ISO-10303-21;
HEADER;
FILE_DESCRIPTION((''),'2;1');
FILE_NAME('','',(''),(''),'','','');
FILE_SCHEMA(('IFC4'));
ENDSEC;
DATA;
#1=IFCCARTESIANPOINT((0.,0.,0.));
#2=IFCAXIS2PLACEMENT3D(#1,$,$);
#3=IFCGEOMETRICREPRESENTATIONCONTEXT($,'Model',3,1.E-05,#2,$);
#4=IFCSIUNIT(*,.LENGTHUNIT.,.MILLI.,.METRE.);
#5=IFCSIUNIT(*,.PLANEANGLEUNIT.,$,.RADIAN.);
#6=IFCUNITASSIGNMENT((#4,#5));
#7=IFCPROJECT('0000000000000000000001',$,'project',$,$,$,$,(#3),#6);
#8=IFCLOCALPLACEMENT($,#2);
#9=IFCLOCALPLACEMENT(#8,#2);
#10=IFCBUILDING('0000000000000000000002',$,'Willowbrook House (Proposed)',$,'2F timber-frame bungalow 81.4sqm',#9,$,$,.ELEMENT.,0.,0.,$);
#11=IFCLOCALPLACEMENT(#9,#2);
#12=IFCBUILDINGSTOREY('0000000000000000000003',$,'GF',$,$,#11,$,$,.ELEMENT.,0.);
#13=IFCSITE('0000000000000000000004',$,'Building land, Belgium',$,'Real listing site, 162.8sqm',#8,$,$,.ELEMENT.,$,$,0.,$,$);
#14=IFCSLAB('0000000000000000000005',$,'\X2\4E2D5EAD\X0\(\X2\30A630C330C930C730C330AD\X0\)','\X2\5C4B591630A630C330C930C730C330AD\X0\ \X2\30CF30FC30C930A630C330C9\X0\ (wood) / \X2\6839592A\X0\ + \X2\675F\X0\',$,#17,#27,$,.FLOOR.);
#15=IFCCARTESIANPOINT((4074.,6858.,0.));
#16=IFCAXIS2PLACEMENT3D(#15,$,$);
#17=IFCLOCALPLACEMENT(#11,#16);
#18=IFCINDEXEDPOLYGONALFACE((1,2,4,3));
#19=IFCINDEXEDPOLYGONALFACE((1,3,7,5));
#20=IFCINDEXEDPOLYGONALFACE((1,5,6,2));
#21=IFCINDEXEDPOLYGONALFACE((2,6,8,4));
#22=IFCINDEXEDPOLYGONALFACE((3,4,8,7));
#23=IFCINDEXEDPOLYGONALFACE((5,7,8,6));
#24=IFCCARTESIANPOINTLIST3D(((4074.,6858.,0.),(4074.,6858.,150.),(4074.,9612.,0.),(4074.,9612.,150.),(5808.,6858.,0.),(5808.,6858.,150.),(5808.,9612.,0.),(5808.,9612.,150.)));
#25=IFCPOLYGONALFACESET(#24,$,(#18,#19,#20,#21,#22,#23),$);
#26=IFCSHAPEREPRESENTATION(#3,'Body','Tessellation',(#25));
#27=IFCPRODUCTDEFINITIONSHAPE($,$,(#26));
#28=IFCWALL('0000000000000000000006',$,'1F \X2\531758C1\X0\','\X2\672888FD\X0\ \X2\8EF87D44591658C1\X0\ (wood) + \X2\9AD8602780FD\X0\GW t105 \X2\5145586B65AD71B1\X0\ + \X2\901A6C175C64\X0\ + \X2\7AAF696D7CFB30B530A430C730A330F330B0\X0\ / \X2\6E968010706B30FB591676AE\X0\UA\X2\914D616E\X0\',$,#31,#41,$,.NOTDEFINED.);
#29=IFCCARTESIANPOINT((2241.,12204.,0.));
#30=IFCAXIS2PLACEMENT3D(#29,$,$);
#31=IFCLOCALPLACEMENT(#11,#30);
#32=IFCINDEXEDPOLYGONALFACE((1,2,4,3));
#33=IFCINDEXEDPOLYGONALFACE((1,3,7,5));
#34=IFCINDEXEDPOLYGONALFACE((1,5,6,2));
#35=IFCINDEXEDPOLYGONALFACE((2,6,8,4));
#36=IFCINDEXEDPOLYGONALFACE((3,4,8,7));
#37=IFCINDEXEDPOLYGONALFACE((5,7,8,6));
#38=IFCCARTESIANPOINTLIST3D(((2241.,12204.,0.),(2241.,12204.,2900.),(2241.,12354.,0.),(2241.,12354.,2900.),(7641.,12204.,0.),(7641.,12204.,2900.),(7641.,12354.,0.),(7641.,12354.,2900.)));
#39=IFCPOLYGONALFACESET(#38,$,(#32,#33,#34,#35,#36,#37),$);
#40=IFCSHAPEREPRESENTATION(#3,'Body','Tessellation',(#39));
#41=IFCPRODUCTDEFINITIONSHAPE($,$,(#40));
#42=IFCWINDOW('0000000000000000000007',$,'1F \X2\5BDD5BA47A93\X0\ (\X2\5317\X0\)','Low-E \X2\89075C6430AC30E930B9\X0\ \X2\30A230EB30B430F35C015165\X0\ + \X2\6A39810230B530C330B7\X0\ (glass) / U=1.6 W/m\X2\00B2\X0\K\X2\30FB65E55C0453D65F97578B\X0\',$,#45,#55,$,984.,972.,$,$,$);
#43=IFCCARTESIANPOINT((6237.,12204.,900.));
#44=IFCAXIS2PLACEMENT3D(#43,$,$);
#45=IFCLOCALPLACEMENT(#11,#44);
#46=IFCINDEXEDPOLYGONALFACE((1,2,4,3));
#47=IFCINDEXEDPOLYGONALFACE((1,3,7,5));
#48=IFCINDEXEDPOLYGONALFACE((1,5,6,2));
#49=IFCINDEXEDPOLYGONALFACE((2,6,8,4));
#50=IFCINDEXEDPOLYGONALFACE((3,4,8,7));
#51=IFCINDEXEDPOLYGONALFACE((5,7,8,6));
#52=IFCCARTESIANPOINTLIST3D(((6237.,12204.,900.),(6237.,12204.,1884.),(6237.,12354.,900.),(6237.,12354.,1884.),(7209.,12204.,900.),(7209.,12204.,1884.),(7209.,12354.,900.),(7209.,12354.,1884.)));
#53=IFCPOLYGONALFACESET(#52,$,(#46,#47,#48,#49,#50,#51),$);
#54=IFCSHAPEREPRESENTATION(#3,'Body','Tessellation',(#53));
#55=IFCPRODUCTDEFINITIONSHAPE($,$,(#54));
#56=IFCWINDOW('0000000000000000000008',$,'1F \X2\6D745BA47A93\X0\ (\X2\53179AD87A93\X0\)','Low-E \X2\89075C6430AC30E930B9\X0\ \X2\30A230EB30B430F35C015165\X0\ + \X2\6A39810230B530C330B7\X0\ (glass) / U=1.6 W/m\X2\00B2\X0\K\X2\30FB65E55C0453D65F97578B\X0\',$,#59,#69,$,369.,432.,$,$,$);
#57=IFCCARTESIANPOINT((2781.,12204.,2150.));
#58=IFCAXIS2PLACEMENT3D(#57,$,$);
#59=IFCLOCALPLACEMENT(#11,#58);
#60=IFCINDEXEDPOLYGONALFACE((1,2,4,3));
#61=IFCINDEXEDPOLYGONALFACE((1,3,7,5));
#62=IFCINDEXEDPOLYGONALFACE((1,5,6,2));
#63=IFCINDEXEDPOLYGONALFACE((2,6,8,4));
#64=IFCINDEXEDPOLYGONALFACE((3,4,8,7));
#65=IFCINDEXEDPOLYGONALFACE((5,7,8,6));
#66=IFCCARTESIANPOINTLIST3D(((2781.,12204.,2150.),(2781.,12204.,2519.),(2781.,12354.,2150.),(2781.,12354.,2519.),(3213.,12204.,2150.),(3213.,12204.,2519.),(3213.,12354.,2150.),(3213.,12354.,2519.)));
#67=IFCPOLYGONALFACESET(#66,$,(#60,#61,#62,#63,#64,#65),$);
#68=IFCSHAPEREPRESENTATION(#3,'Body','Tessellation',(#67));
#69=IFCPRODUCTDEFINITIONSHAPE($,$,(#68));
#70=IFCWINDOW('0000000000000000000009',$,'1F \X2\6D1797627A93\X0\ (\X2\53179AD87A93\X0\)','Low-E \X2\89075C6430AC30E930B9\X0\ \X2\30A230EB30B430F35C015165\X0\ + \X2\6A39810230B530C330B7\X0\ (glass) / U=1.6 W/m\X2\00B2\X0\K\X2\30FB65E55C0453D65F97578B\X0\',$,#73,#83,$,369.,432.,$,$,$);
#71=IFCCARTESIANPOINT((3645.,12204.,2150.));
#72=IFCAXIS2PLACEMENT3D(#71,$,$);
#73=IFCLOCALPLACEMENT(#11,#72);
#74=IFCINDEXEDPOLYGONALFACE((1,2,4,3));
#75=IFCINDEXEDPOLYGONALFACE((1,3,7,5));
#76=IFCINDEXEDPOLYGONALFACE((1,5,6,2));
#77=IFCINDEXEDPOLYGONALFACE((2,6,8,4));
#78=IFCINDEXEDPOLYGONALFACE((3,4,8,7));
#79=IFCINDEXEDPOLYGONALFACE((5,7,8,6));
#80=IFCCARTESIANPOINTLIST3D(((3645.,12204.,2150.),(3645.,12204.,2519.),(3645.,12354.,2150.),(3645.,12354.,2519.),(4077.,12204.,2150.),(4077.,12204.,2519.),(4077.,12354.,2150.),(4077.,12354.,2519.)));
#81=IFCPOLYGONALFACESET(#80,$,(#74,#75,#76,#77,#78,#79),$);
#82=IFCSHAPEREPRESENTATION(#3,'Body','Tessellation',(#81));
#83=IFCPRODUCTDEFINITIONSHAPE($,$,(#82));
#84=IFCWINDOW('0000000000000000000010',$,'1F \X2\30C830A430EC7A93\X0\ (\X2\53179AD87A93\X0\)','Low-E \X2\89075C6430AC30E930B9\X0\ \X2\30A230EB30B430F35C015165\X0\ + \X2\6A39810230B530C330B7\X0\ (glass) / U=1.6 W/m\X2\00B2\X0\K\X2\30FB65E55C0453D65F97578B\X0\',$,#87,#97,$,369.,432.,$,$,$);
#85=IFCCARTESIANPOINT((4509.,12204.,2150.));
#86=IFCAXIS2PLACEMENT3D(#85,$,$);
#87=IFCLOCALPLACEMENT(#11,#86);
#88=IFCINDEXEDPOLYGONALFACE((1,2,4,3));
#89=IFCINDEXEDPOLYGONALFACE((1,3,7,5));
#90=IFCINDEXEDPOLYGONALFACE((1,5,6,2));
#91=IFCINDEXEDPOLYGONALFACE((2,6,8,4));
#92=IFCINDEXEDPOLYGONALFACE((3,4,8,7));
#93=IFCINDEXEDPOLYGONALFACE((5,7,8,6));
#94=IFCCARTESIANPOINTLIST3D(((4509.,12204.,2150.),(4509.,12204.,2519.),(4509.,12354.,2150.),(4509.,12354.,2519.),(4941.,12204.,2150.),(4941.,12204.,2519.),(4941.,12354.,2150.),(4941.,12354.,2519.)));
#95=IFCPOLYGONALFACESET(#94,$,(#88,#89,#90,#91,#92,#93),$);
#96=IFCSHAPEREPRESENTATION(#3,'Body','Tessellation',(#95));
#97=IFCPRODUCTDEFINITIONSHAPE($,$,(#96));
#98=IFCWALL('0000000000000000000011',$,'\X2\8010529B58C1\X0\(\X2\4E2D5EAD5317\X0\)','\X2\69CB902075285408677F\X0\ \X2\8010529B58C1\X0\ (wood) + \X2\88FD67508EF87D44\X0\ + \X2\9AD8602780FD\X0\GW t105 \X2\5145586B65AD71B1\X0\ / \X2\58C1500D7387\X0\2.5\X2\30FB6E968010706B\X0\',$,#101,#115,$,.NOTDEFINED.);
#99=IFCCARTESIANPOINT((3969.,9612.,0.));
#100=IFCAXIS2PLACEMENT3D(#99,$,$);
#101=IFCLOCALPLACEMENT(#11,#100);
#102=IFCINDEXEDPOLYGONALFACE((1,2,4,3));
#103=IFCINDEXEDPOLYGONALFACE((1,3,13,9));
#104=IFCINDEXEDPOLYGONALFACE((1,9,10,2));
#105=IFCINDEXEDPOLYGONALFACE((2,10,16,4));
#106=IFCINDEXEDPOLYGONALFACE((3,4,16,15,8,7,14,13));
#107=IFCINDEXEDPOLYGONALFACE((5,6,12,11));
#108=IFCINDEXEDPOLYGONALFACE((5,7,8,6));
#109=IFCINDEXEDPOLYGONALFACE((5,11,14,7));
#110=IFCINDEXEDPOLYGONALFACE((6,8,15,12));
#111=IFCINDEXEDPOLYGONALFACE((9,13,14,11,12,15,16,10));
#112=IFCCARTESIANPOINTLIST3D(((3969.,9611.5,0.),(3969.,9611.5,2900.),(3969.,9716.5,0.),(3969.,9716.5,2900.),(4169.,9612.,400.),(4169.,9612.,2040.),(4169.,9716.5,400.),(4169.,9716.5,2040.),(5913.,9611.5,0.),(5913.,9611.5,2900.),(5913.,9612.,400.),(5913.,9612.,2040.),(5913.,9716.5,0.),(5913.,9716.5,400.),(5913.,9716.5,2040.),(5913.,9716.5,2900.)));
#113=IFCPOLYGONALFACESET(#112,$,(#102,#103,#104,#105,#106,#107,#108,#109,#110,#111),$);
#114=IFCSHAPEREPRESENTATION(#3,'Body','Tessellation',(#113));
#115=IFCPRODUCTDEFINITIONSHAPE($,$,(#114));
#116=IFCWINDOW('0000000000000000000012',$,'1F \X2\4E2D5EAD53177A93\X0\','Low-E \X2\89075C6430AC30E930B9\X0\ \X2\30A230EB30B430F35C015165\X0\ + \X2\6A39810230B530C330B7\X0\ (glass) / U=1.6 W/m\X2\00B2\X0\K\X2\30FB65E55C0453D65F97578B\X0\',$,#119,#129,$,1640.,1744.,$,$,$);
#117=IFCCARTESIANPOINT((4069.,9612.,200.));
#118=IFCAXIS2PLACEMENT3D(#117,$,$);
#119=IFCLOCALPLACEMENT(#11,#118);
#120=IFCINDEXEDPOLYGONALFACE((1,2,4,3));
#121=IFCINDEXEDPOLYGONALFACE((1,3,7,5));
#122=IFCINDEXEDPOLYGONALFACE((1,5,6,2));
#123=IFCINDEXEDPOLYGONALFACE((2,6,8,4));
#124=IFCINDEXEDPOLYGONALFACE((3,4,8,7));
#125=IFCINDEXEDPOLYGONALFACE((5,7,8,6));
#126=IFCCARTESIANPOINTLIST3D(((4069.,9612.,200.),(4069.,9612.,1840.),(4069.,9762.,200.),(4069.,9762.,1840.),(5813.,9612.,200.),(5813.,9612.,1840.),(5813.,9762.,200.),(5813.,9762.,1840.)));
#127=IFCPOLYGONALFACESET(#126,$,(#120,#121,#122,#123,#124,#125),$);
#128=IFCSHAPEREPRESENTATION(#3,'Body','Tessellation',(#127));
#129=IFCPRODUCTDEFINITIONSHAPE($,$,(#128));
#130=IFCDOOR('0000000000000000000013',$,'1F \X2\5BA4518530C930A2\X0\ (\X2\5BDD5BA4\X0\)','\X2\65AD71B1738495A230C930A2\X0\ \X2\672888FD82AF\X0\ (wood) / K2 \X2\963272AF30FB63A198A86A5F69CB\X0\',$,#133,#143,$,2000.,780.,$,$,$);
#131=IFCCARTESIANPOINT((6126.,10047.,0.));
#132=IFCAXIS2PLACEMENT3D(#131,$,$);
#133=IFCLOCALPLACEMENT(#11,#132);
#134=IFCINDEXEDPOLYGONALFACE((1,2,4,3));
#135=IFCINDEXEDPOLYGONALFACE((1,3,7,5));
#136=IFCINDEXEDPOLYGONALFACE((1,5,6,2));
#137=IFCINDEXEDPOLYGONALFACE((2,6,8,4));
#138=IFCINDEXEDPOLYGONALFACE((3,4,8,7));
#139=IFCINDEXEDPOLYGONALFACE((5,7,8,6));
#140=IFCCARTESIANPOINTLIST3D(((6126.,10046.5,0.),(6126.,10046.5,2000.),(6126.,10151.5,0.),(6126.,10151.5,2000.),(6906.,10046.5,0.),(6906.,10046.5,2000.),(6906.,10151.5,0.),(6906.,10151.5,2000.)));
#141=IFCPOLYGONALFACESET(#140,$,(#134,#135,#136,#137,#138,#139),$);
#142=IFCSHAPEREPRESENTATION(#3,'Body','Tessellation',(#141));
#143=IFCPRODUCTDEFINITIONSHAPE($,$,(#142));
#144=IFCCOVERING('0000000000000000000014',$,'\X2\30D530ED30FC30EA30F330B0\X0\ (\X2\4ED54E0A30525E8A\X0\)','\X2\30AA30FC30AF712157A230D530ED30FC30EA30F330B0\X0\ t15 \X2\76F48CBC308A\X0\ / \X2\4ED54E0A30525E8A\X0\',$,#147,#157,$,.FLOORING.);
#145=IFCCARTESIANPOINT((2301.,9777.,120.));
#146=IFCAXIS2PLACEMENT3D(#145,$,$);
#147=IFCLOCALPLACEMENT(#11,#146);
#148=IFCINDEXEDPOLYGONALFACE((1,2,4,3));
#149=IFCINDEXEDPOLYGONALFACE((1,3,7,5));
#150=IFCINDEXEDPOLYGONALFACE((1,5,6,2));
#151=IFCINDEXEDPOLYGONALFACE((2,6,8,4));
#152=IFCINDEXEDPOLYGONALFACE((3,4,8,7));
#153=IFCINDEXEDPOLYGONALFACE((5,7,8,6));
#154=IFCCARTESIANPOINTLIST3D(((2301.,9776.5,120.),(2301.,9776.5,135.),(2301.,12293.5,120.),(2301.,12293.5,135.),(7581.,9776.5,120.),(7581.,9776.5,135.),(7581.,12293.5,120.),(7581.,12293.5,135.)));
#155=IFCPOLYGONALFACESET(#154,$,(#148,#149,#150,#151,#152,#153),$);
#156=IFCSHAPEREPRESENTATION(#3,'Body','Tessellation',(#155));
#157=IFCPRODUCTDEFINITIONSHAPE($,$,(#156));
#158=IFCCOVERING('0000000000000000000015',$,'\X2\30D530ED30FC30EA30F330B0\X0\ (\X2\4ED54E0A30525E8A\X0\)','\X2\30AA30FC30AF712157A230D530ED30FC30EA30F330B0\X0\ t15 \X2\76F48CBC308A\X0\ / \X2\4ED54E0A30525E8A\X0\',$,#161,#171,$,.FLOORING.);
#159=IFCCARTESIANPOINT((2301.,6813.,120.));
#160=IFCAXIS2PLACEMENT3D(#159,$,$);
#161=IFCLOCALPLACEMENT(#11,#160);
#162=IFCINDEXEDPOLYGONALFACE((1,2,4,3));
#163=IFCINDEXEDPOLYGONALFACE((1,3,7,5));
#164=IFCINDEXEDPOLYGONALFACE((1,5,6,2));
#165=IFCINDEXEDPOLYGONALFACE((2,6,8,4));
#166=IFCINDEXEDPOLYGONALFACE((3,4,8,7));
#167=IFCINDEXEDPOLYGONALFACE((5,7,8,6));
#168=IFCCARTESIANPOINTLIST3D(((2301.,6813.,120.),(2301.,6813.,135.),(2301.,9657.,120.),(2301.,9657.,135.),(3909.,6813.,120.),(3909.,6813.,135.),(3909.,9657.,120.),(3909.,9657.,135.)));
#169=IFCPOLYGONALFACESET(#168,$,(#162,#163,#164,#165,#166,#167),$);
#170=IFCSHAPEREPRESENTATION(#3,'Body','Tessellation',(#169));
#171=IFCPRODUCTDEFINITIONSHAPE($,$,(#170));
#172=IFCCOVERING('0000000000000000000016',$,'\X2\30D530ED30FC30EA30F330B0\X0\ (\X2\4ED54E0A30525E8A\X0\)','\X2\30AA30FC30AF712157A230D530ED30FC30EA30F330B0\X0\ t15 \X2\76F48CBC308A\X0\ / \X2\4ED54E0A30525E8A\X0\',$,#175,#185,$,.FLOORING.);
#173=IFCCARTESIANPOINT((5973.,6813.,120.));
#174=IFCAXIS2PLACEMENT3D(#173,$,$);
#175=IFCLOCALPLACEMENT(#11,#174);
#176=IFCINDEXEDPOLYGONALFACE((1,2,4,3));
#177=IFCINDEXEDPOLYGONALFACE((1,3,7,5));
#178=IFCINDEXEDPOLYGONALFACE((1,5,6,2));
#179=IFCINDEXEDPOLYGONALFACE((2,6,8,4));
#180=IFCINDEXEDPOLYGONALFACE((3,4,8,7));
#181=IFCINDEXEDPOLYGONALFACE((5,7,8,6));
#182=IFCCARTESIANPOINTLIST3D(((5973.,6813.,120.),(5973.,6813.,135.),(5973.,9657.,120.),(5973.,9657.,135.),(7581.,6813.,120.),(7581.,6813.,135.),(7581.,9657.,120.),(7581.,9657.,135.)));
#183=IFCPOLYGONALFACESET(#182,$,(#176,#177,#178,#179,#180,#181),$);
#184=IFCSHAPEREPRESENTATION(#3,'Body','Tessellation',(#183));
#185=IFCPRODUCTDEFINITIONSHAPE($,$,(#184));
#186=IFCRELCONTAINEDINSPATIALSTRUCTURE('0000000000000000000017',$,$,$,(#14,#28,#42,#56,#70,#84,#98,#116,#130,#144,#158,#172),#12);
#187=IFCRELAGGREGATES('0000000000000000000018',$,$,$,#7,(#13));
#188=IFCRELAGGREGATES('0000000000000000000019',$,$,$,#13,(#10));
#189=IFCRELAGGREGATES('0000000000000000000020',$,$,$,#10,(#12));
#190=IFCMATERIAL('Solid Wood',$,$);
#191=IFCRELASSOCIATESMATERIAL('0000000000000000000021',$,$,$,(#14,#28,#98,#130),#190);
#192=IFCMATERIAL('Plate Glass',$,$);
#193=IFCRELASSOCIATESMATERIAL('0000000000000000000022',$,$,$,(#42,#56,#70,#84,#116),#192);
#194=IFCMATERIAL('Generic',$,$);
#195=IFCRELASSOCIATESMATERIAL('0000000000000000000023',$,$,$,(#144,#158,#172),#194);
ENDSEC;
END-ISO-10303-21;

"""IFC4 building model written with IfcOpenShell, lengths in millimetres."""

from ifc_helpers import new_model, si_unit, frame, frame_2d, origin, place, context, project, spatial, rectangle, extrude, material, element, fill, save


model = new_model("IFC4")

# Units and contexts
model_context = context("Model", 3, precision=1e-05, world=origin())
ifc_project = project(units=[si_unit("LENGTHUNIT", "METRE", prefix="MILLI"), si_unit("PLANEANGLEUNIT", "RADIAN")], contexts=[model_context])

# Site, building, storey
site_placement = place(None, origin())
site = spatial("IfcSite", under=ifc_project, at=site_placement, Name="Building land, Belgium", ObjectType="Real listing site, 162.8sqm", CompositionType="ELEMENT", RefElevation=0.0)
building_placement = place(site_placement, origin())
building = spatial("IfcBuilding", under=site, at=building_placement, Name="Willowbrook House (Proposed)", ObjectType="2F timber-frame bungalow 81.4sqm", CompositionType="ELEMENT", ElevationOfRefHeight=0.0, ElevationOfTerrain=0.0)
storey_placement = place(building_placement, origin())
storey = spatial("IfcBuildingStorey", under=building, at=storey_placement, Name="GF", CompositionType="ELEMENT", Elevation=0.0)

# Slab
ifc_material_1 = material(Name="Solid Wood")
slab_1_placement = place(storey_placement, frame((4074.0, 6858.0, 0.0)))
element("IfcSlab", 1, at=slab_1_placement, inside=storey, material=ifc_material_1, Name="中庭(ウッドデッキ)", Description="屋外ウッドデッキ ハードウッド (wood) / 根太 + 束", PredefinedType="FLOOR", context=model_context, shape_type="SweptSolid", body=[
    extrude(rectangle(XDim=1734.0, YDim=2754.0, at=frame_2d((867.0, 1377.0))), frame((4074.0, 6858.0, 0.0)), (0.0, 0.0, 1.0), 150.0),
])

# Wall, openings, windows
wall_1_placement = place(storey_placement, frame((2241.0, 12204.0, 0.0)))
wall_1 = element("IfcWall", 2, at=wall_1_placement, inside=storey, material=ifc_material_1, Name="1F 北壁", Description="木製 軸組外壁 (wood) + 高性能GW t105 充填断熱 + 通気層 + 窯業系サイディング / 準耐火・外皮UA配慮", PredefinedType="NOTDEFINED", context=model_context, shape_type="SweptSolid", body=[
    extrude(rectangle(XDim=5400.0, YDim=150.0, at=frame_2d((2700.0, 75.0))), frame((2241.0, 12204.0, 0.0)), (0.0, 0.0, 1.0), 2900.0),
])
opening_1_placement = place(storey_placement, frame((6237.0, 12204.0, 900.0)))
opening_1 = element("IfcOpeningElement", 3, at=opening_1_placement, cuts=wall_1, PredefinedType="NOTDEFINED", context=model_context, shape_type="SweptSolid", body=[
    extrude(rectangle(XDim=972.0, YDim=150.0, at=frame_2d((486.0, 75.0))), frame((6237.0, 12204.0, 900.0)), (0.0, 0.0, 1.0), 984.0),
])
opening_2_placement = place(storey_placement, frame((2781.0, 12204.0, 2150.0)))
opening_2 = element("IfcOpeningElement", 4, at=opening_2_placement, cuts=wall_1, PredefinedType="NOTDEFINED", context=model_context, shape_type="SweptSolid", body=[
    extrude(rectangle(XDim=432.0, YDim=150.0, at=frame_2d((216.0, 75.0))), frame((2781.0, 12204.0, 2150.0)), (0.0, 0.0, 1.0), 369.0),
])
opening_3_placement = place(storey_placement, frame((3645.0, 12204.0, 2150.0)))
opening_3 = element("IfcOpeningElement", 5, at=opening_3_placement, cuts=wall_1, PredefinedType="NOTDEFINED", context=model_context, shape_type="SweptSolid", body=[
    extrude(rectangle(XDim=432.0, YDim=150.0, at=frame_2d((216.0, 75.0))), frame((3645.0, 12204.0, 2150.0)), (0.0, 0.0, 1.0), 369.0),
])
opening_4_placement = place(storey_placement, frame((4509.0, 12204.0, 2150.0)))
opening_4 = element("IfcOpeningElement", 6, at=opening_4_placement, cuts=wall_1, PredefinedType="NOTDEFINED", context=model_context, shape_type="SweptSolid", body=[
    extrude(rectangle(XDim=432.0, YDim=150.0, at=frame_2d((216.0, 75.0))), frame((4509.0, 12204.0, 2150.0)), (0.0, 0.0, 1.0), 369.0),
])
ifc_material_2 = material(Name="Plate Glass")
window_1_placement = place(storey_placement, frame((6237.0, 12204.0, 900.0)))
window_1 = element("IfcWindow", 7, at=window_1_placement, inside=storey, material=ifc_material_2, Name="1F 寝室窓 (北)", Description="Low-E 複層ガラス アルゴン封入 + 樹脂サッシ (glass) / U=1.6 W/m²K・日射取得型", OverallHeight=984.0, OverallWidth=972.0, context=model_context, shape_type="SweptSolid", body=[
    extrude(rectangle(XDim=972.0, YDim=150.0, at=frame_2d((486.0, 75.0))), frame((6237.0, 12204.0, 900.0)), (0.0, 0.0, 1.0), 984.0),
])
fill(opening_1, window_1)
window_2_placement = place(storey_placement, frame((2781.0, 12204.0, 2150.0)))
window_2 = element("IfcWindow", 8, at=window_2_placement, inside=storey, material=ifc_material_2, Name="1F 浴室窓 (北高窓)", Description="Low-E 複層ガラス アルゴン封入 + 樹脂サッシ (glass) / U=1.6 W/m²K・日射取得型", OverallHeight=369.0, OverallWidth=432.0, context=model_context, shape_type="SweptSolid", body=[
    extrude(rectangle(XDim=432.0, YDim=150.0, at=frame_2d((216.0, 75.0))), frame((2781.0, 12204.0, 2150.0)), (0.0, 0.0, 1.0), 369.0),
])
fill(opening_2, window_2)
window_3_placement = place(storey_placement, frame((3645.0, 12204.0, 2150.0)))
window_3 = element("IfcWindow", 9, at=window_3_placement, inside=storey, material=ifc_material_2, Name="1F 洗面窓 (北高窓)", Description="Low-E 複層ガラス アルゴン封入 + 樹脂サッシ (glass) / U=1.6 W/m²K・日射取得型", OverallHeight=369.0, OverallWidth=432.0, context=model_context, shape_type="SweptSolid", body=[
    extrude(rectangle(XDim=432.0, YDim=150.0, at=frame_2d((216.0, 75.0))), frame((3645.0, 12204.0, 2150.0)), (0.0, 0.0, 1.0), 369.0),
])
fill(opening_3, window_3)
window_4_placement = place(storey_placement, frame((4509.0, 12204.0, 2150.0)))
window_4 = element("IfcWindow", 10, at=window_4_placement, inside=storey, material=ifc_material_2, Name="1F トイレ窓 (北高窓)", Description="Low-E 複層ガラス アルゴン封入 + 樹脂サッシ (glass) / U=1.6 W/m²K・日射取得型", OverallHeight=369.0, OverallWidth=432.0, context=model_context, shape_type="SweptSolid", body=[
    extrude(rectangle(XDim=432.0, YDim=150.0, at=frame_2d((216.0, 75.0))), frame((4509.0, 12204.0, 2150.0)), (0.0, 0.0, 1.0), 369.0),
])
fill(opening_4, window_4)

# Wall, opening, window
wall_2_placement = place(storey_placement, frame((3969.0, 9612.0, 0.0)))
wall_2 = element("IfcWall", 11, at=wall_2_placement, inside=storey, material=ifc_material_1, Name="耐力壁(中庭北)", Description="構造用合板 耐力壁 (wood) + 製材軸組 + 高性能GW t105 充填断熱 / 壁倍率2.5・準耐火", PredefinedType="NOTDEFINED", context=model_context, shape_type="SweptSolid", body=[
    extrude(rectangle(XDim=1944.0, YDim=105.0, at=frame_2d((972.0, 52.0))), frame((3969.0, 9612.0, 0.0)), (0.0, 0.0, 1.0), 2900.0),
])
opening_5_placement = place(storey_placement, frame((4069.0, 9612.0, 200.0)))
opening_5 = element("IfcOpeningElement", 12, at=opening_5_placement, cuts=wall_2, PredefinedType="NOTDEFINED", context=model_context, shape_type="SweptSolid", body=[
    extrude(rectangle(XDim=1744.0, YDim=150.0, at=frame_2d((872.0, 75.0))), frame((4069.0, 9612.0, 200.0)), (0.0, 0.0, 1.0), 1640.0),
])
window_5_placement = place(storey_placement, frame((4069.0, 9612.0, 200.0)))
window_5 = element("IfcWindow", 13, at=window_5_placement, inside=storey, material=ifc_material_2, Name="1F 中庭北窓", Description="Low-E 複層ガラス アルゴン封入 + 樹脂サッシ (glass) / U=1.6 W/m²K・日射取得型", OverallHeight=1640.0, OverallWidth=1744.0, context=model_context, shape_type="SweptSolid", body=[
    extrude(rectangle(XDim=1744.0, YDim=150.0, at=frame_2d((872.0, 75.0))), frame((4069.0, 9612.0, 200.0)), (0.0, 0.0, 1.0), 1640.0),
])
fill(opening_5, window_5)

# Door
door_1_placement = place(storey_placement, frame((6126.0, 10047.0, 0.0)))
element("IfcDoor", 14, at=door_1_placement, inside=storey, material=ifc_material_1, Name="1F 室内ドア (寝室)", Description="断熱玄関ドア 木製芯 (wood) / K2 防犯・採風機構", OverallHeight=2000.0, OverallWidth=780.0, context=model_context, shape_type="SweptSolid", body=[
    extrude(rectangle(XDim=780.0, YDim=105.0, at=frame_2d((390.0, 52.0))), frame((6126.0, 10047.0, 0.0)), (0.0, 0.0, 1.0), 2000.0),
])

# Coverings
ifc_material_3 = material(Name="Generic")
covering_1_placement = place(storey_placement, frame((2301.0, 9777.0, 120.0)))
element("IfcCovering", 15, at=covering_1_placement, inside=storey, material=ifc_material_3, Name="フローリング (仕上げ床)", Description="オーク無垢フローリング t15 直貼り / 仕上げ床", PredefinedType="FLOORING", context=model_context, shape_type="SweptSolid", body=[
    extrude(rectangle(XDim=5280.0, YDim=2517.0, at=frame_2d((2640.0, 1258.0))), frame((2301.0, 9777.0, 120.0)), (0.0, 0.0, 1.0), 15.0),
])
covering_2_placement = place(storey_placement, frame((2301.0, 6813.0, 120.0)))
element("IfcCovering", 16, at=covering_2_placement, inside=storey, material=ifc_material_3, Name="フローリング (仕上げ床)", Description="オーク無垢フローリング t15 直貼り / 仕上げ床", PredefinedType="FLOORING", context=model_context, shape_type="SweptSolid", body=[
    extrude(rectangle(XDim=1608.0, YDim=2844.0, at=frame_2d((804.0, 1422.0))), frame((2301.0, 6813.0, 120.0)), (0.0, 0.0, 1.0), 15.0),
])
covering_3_placement = place(storey_placement, frame((5973.0, 6813.0, 120.0)))
element("IfcCovering", 17, at=covering_3_placement, inside=storey, material=ifc_material_3, Name="フローリング (仕上げ床)", Description="オーク無垢フローリング t15 直貼り / 仕上げ床", PredefinedType="FLOORING", context=model_context, shape_type="SweptSolid", body=[
    extrude(rectangle(XDim=1608.0, YDim=2844.0, at=frame_2d((804.0, 1422.0))), frame((5973.0, 6813.0, 120.0)), (0.0, 0.0, 1.0), 15.0),
])

save(model, "model.ifc")
